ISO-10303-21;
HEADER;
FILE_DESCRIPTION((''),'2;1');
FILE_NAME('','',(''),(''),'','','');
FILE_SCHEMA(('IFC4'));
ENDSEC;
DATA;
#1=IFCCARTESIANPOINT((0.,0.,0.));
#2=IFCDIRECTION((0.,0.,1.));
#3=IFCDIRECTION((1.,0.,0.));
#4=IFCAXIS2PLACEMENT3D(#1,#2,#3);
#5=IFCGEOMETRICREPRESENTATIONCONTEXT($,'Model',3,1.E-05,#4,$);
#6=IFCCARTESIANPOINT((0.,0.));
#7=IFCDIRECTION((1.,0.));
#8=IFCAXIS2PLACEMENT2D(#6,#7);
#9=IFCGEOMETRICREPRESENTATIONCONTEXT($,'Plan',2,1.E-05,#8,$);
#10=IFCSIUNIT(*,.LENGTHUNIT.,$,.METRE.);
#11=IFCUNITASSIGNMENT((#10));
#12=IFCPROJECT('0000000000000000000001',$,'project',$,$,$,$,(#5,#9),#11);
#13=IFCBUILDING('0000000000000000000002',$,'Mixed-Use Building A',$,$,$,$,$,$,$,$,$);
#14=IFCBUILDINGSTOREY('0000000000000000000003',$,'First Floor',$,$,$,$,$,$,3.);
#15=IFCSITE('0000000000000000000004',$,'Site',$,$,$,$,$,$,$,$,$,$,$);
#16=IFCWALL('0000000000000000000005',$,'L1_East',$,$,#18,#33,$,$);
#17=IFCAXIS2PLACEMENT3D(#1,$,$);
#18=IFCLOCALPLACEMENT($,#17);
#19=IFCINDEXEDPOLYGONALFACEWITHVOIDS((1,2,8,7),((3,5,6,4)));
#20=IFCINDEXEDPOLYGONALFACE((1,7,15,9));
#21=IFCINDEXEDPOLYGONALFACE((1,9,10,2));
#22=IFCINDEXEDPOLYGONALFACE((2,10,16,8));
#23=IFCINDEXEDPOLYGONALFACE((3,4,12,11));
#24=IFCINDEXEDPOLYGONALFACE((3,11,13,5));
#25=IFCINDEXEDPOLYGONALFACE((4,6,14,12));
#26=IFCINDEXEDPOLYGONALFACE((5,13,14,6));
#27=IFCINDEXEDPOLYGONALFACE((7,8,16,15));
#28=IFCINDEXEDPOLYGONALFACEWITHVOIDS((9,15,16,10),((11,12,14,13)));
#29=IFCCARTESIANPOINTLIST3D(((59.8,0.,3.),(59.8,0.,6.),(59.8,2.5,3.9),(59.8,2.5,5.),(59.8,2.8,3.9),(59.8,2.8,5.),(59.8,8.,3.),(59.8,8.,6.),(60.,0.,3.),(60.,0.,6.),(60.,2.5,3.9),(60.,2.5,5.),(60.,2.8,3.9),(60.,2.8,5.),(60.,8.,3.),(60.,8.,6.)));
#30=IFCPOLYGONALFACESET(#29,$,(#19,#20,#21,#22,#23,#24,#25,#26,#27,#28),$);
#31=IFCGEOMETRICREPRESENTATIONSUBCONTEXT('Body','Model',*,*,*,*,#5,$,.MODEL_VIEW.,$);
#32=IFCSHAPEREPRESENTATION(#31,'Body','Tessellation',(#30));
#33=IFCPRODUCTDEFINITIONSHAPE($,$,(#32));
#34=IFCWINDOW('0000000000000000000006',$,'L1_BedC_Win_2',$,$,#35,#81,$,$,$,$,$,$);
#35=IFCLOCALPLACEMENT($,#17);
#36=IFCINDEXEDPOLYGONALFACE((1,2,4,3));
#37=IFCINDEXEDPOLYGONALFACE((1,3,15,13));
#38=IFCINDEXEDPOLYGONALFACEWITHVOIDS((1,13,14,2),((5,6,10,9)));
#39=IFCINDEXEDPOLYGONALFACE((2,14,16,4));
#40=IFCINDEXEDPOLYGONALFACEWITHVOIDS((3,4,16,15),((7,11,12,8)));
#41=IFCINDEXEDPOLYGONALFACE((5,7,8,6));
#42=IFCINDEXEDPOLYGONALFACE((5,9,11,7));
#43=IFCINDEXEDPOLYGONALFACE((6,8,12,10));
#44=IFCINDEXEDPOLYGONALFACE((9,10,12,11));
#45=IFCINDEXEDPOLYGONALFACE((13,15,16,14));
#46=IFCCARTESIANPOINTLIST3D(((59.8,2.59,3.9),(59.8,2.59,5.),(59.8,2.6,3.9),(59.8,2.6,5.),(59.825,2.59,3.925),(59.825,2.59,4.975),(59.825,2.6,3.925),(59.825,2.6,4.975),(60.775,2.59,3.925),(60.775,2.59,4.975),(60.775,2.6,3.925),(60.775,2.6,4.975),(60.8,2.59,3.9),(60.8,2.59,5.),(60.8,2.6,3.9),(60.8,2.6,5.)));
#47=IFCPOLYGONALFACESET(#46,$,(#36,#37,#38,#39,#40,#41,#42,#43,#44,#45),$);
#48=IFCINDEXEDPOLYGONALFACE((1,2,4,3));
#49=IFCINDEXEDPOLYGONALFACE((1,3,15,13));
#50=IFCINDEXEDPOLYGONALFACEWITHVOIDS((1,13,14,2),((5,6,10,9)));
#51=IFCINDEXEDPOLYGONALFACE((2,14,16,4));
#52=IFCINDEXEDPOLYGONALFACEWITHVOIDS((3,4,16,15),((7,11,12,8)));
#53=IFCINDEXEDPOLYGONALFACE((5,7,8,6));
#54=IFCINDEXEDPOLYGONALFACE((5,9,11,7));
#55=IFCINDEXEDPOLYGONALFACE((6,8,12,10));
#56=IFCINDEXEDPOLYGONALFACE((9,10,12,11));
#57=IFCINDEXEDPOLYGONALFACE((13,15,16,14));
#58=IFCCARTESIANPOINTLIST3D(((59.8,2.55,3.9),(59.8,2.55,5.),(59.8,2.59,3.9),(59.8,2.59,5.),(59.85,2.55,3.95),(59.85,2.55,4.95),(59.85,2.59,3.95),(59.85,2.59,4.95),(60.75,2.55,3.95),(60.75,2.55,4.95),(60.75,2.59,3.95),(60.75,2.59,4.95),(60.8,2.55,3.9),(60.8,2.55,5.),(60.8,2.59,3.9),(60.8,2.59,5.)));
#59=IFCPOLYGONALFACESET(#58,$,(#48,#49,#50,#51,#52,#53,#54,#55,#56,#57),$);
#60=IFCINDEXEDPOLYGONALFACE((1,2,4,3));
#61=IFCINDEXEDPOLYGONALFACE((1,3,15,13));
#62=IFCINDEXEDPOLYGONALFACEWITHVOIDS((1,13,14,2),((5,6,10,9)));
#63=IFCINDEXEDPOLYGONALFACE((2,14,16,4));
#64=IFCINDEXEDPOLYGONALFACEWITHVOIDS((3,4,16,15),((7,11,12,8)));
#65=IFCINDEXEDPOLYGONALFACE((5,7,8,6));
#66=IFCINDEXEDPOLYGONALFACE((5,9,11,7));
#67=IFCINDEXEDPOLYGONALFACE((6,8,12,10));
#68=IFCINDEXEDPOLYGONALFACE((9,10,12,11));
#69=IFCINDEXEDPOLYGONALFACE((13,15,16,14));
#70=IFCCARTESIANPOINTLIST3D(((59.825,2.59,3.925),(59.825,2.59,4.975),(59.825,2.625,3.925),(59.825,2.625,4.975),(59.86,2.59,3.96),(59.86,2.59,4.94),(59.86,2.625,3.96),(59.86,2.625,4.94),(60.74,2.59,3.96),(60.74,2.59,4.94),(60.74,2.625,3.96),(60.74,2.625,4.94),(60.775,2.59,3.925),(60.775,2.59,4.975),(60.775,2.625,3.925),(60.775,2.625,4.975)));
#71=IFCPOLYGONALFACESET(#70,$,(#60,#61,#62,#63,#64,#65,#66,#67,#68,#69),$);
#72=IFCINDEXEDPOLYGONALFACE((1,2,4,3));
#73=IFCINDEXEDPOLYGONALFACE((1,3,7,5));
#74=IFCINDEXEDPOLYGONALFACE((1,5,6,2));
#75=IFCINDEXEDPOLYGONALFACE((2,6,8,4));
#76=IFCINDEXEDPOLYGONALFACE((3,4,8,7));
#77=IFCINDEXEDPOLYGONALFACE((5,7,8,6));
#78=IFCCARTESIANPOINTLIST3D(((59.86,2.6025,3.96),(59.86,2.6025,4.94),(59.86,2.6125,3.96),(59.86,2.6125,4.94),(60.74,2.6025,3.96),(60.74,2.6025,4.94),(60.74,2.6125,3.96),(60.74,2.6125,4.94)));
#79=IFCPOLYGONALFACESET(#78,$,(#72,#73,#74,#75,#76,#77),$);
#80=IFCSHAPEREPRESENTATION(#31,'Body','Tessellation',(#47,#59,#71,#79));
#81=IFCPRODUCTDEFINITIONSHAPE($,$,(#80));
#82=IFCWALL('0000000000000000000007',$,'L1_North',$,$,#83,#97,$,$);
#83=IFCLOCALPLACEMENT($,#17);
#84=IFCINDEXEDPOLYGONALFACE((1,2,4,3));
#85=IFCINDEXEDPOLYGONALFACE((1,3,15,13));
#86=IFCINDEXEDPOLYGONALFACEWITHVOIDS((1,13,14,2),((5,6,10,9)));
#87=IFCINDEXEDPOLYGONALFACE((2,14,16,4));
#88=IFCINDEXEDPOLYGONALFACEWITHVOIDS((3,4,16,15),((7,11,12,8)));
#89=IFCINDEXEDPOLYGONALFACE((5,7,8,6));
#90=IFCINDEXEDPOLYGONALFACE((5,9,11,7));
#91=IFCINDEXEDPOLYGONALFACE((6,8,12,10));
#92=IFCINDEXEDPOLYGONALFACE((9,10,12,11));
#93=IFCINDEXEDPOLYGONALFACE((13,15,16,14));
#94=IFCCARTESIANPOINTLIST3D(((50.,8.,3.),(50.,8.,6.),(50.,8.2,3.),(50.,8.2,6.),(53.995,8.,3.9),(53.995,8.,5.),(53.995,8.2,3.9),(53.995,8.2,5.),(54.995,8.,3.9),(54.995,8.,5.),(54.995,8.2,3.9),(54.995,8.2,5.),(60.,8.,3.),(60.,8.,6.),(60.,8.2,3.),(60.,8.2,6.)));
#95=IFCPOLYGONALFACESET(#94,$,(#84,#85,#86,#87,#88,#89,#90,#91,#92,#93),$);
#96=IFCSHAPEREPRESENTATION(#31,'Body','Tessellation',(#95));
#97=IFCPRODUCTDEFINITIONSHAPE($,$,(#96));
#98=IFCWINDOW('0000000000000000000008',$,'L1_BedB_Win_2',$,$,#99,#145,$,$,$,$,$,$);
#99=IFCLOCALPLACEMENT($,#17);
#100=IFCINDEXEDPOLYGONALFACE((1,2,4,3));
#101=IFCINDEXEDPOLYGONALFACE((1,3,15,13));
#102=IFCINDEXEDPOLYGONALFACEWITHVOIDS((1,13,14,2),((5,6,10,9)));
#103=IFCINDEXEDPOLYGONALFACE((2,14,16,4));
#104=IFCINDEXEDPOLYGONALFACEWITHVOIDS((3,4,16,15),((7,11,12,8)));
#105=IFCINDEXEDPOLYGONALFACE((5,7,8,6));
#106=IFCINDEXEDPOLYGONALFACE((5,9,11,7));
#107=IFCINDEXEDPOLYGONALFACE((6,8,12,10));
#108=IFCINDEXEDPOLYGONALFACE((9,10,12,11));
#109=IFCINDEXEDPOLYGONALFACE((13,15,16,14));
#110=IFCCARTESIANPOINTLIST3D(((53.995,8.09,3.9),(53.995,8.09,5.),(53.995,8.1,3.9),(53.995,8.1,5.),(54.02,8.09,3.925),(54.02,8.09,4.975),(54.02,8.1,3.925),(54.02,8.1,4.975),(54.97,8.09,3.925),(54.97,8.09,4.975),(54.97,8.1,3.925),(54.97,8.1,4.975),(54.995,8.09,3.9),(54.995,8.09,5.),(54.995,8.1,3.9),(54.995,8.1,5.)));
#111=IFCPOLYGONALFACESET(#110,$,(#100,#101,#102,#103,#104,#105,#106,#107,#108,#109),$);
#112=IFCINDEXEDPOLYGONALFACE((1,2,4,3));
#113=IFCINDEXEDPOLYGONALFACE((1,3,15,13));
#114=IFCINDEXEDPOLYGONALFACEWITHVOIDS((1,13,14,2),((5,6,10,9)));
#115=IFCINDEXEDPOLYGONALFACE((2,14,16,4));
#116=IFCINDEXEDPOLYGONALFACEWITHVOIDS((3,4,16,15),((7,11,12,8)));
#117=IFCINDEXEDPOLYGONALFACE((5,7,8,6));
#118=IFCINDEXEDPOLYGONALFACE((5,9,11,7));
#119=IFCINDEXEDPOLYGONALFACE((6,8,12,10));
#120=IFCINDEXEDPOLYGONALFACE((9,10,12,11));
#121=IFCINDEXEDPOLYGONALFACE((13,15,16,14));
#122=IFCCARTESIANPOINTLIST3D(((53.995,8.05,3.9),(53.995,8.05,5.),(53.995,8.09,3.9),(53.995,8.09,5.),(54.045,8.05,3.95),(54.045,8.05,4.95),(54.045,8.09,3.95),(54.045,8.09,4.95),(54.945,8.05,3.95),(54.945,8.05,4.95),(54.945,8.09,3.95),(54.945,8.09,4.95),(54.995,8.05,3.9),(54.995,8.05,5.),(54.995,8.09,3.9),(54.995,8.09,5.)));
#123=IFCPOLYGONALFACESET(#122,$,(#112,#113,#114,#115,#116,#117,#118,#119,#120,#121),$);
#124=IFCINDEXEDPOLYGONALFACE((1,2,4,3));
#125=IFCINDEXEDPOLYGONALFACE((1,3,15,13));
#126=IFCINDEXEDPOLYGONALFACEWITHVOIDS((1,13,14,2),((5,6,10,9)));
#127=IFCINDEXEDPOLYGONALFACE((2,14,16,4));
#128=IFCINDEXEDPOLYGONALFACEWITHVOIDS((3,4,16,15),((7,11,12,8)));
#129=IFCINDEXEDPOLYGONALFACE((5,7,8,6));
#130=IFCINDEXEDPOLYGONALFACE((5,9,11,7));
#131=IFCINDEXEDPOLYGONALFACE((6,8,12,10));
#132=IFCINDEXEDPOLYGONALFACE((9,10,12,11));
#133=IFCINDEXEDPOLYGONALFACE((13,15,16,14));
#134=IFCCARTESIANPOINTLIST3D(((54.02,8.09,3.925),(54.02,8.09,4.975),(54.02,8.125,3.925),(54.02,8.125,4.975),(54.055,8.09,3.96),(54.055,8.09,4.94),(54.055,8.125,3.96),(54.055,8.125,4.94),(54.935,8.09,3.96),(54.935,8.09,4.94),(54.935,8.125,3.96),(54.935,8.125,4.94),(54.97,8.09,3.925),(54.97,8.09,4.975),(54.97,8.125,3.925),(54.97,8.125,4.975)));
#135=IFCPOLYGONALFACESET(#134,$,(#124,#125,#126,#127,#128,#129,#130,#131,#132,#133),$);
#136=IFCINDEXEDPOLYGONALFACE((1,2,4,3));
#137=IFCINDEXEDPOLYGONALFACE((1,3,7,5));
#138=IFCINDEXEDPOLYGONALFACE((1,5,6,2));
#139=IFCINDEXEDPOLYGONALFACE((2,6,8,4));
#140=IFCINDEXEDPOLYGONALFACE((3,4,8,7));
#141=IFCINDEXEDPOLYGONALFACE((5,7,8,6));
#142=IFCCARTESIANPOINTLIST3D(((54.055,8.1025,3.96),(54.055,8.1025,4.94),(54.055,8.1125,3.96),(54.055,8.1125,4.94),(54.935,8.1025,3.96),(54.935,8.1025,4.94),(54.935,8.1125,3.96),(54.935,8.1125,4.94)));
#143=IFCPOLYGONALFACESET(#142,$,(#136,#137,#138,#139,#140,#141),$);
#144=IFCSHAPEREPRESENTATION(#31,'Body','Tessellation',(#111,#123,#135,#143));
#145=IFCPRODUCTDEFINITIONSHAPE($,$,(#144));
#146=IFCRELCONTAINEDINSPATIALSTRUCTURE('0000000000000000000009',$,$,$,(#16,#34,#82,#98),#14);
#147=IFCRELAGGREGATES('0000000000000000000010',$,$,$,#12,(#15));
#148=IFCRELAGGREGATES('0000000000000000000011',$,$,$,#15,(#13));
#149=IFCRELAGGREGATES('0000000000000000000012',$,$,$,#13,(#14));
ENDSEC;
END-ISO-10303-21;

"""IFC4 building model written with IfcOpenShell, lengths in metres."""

from ifc_helpers import new_model, si_unit, frame, origin_with_axes, origin_2d_with_axis, place, context, subcontext, project, spatial, line, indexed_curve, outline, extrude, element, fill, save


model = new_model("IFC4")

# Units and contexts
model_context = context("Model", 3, precision=1e-05, world=origin_with_axes())
plan_context = context("Plan", 2, precision=1e-05, world=origin_2d_with_axis())
body_context = subcontext(model_context, "Body", "Model", "MODEL_VIEW")
ifc_project = project(units=[si_unit("LENGTHUNIT", "METRE")], contexts=[model_context, plan_context])

# Site, building, storey
site = spatial("IfcSite", under=ifc_project, Name="Site")
building = spatial("IfcBuilding", under=site, Name="Mixed-Use Building A")
storey = spatial("IfcBuildingStorey", under=building, Name="First Floor", Elevation=3.0)

# Walls, openings, windows
wall_1_placement = place(None, frame((60.0, 0.0, 3.0), z_axis=(0.0, 0.0, 1.0), x_axis=(0.0, 1.0, 0.0)))
wall_1 = element("IfcWall", 1, at=wall_1_placement, inside=storey, Name="L1_East", context=body_context, shape_type="SweptSolid", body=[
    extrude(outline(indexed_curve([(0.0, 0.0), (0.0, 0.2), (8.0, 0.2), (8.0, 0.0), (0.0, 0.0)], self_intersect=False)), origin_with_axes(), (0.0, 0.0, 1.0), 3.0),
])
opening_1_placement = place(wall_1_placement, frame((2.5, 0.2, 0.9), z_axis=(0.0, 0.0, 1.0), x_axis=(0.0, -1.0, 0.0)))
opening_1 = element("IfcOpeningElement", 2, at=opening_1_placement, cuts=wall_1, context=body_context, shape_type="SweptSolid", body=[
    extrude(outline(indexed_curve([(0.0, 0.0), (0.0, 0.3), (1.0, 0.3), (1.0, 0.0), (0.0, 0.0)], self_intersect=False)), origin_with_axes(), (0.0, 0.0, 1.0), 1.1),
])
window_1_placement = place(None, frame((59.8, 2.5, 3.9), z_axis=(0.0, 0.0, 1.0), x_axis=(1.0, 0.0, 0.0)))
window_1 = element("IfcWindow", 3, at=window_1_placement, inside=storey, Name="L1_BedC_Win_2", context=body_context, shape_type="SweptSolid", body=[
    extrude(outline(indexed_curve([(0.0, 0.0), (1.0, 0.0), (1.0, 1.1), (0.0, 1.1)], segments=[line(1, 2, 3, 4, 1)]), holes=[indexed_curve([(0.025, 0.025), (0.975, 0.025), (0.975, 1.075), (0.025, 1.075)], segments=[line(1, 2, 3, 4, 1)])]), frame((0.0, 0.09, 0.0), z_axis=(0.0, -1.0, 0.0), x_axis=(1.0, 0.0, 0.0)), (0.0, 0.0, -1.0), 0.01),
    extrude(outline(indexed_curve([(0.0, 0.0), (1.0, 0.0), (1.0, 1.1), (0.0, 1.1)], segments=[line(1, 2, 3, 4, 1)]), holes=[indexed_curve([(0.05, 0.05), (0.95, 0.05), (0.95, 1.05), (0.05, 1.05)], segments=[line(1, 2, 3, 4, 1)])]), frame((0.0, 0.05, 0.0), z_axis=(0.0, -1.0, 0.0), x_axis=(1.0, 0.0, 0.0)), (0.0, 0.0, -1.0), 0.04),
    extrude(outline(indexed_curve([(0.0, 0.0), (0.95, 0.0), (0.95, 1.05), (0.0, 1.05)], segments=[line(1, 2, 3, 4, 1)]), holes=[indexed_curve([(0.035, 0.035), (0.915, 0.035), (0.915, 1.015), (0.035, 1.015)], segments=[line(1, 2, 3, 4, 1)])]), frame((0.025, 0.09, 0.025), z_axis=(0.0, -1.0, 0.0), x_axis=(1.0, 0.0, 0.0)), (0.0, 0.0, -1.0), 0.035),
    extrude(outline(indexed_curve([(0.035, 0.035), (0.915, 0.035), (0.915, 1.015), (0.035, 1.015)], segments=[line(1, 2, 3, 4, 1)])), frame((0.025, 0.1025, 0.025), z_axis=(0.0, -1.0, 0.0), x_axis=(1.0, 0.0, 0.0)), (0.0, 0.0, -1.0), 0.01),
])
fill(opening_1, window_1)
wall_2_placement = place(None, frame((50.0, 8.0, 3.0), z_axis=(0.0, 0.0, 1.0), x_axis=(1.0, 0.0, 0.0)))
wall_2 = element("IfcWall", 4, at=wall_2_placement, inside=storey, Name="L1_North", context=body_context, shape_type="SweptSolid", body=[
    extrude(outline(indexed_curve([(0.0, 0.0), (0.0, 0.2), (10.0, 0.2), (10.0, 0.0), (0.0, 0.0)], self_intersect=False)), origin_with_axes(), (0.0, 0.0, 1.0), 3.0),
])
opening_2_placement = place(wall_2_placement, frame((3.995, 0.0, 0.9), z_axis=(0.0, 0.0, 1.0), x_axis=(1.0, 0.0, 0.0)))
opening_2 = element("IfcOpeningElement", 5, at=opening_2_placement, cuts=wall_2, context=body_context, shape_type="SweptSolid", body=[
    extrude(outline(indexed_curve([(0.0, 0.0), (0.0, 0.3), (1.0, 0.3), (1.0, 0.0), (0.0, 0.0)], self_intersect=False)), origin_with_axes(), (0.0, 0.0, 1.0), 1.1),
])
window_2_placement = place(None, frame((53.995, 8.0, 3.9), z_axis=(0.0, 0.0, 1.0), x_axis=(1.0, 0.0, 0.0)))
window_2 = element("IfcWindow", 6, at=window_2_placement, inside=storey, Name="L1_BedB_Win_2", context=body_context, shape_type="SweptSolid", body=[
    extrude(outline(indexed_curve([(0.0, 0.0), (1.0, 0.0), (1.0, 1.1), (0.0, 1.1)], segments=[line(1, 2, 3, 4, 1)]), holes=[indexed_curve([(0.025, 0.025), (0.975, 0.025), (0.975, 1.075), (0.025, 1.075)], segments=[line(1, 2, 3, 4, 1)])]), frame((0.0, 0.09, 0.0), z_axis=(0.0, -1.0, 0.0), x_axis=(1.0, 0.0, 0.0)), (0.0, 0.0, -1.0), 0.01),
    extrude(outline(indexed_curve([(0.0, 0.0), (1.0, 0.0), (1.0, 1.1), (0.0, 1.1)], segments=[line(1, 2, 3, 4, 1)]), holes=[indexed_curve([(0.05, 0.05), (0.95, 0.05), (0.95, 1.05), (0.05, 1.05)], segments=[line(1, 2, 3, 4, 1)])]), frame((0.0, 0.05, 0.0), z_axis=(0.0, -1.0, 0.0), x_axis=(1.0, 0.0, 0.0)), (0.0, 0.0, -1.0), 0.04),
    extrude(outline(indexed_curve([(0.0, 0.0), (0.95, 0.0), (0.95, 1.05), (0.0, 1.05)], segments=[line(1, 2, 3, 4, 1)]), holes=[indexed_curve([(0.035, 0.035), (0.915, 0.035), (0.915, 1.015), (0.035, 1.015)], segments=[line(1, 2, 3, 4, 1)])]), frame((0.025, 0.09, 0.025), z_axis=(0.0, -1.0, 0.0), x_axis=(1.0, 0.0, 0.0)), (0.0, 0.0, -1.0), 0.035),
    extrude(outline(indexed_curve([(0.035, 0.035), (0.915, 0.035), (0.915, 1.015), (0.035, 1.015)], segments=[line(1, 2, 3, 4, 1)])), frame((0.025, 0.1025, 0.025), z_axis=(0.0, -1.0, 0.0), x_axis=(1.0, 0.0, 0.0)), (0.0, 0.0, -1.0), 0.01),
])
fill(opening_2, window_2)

save(model, "model.ifc")
